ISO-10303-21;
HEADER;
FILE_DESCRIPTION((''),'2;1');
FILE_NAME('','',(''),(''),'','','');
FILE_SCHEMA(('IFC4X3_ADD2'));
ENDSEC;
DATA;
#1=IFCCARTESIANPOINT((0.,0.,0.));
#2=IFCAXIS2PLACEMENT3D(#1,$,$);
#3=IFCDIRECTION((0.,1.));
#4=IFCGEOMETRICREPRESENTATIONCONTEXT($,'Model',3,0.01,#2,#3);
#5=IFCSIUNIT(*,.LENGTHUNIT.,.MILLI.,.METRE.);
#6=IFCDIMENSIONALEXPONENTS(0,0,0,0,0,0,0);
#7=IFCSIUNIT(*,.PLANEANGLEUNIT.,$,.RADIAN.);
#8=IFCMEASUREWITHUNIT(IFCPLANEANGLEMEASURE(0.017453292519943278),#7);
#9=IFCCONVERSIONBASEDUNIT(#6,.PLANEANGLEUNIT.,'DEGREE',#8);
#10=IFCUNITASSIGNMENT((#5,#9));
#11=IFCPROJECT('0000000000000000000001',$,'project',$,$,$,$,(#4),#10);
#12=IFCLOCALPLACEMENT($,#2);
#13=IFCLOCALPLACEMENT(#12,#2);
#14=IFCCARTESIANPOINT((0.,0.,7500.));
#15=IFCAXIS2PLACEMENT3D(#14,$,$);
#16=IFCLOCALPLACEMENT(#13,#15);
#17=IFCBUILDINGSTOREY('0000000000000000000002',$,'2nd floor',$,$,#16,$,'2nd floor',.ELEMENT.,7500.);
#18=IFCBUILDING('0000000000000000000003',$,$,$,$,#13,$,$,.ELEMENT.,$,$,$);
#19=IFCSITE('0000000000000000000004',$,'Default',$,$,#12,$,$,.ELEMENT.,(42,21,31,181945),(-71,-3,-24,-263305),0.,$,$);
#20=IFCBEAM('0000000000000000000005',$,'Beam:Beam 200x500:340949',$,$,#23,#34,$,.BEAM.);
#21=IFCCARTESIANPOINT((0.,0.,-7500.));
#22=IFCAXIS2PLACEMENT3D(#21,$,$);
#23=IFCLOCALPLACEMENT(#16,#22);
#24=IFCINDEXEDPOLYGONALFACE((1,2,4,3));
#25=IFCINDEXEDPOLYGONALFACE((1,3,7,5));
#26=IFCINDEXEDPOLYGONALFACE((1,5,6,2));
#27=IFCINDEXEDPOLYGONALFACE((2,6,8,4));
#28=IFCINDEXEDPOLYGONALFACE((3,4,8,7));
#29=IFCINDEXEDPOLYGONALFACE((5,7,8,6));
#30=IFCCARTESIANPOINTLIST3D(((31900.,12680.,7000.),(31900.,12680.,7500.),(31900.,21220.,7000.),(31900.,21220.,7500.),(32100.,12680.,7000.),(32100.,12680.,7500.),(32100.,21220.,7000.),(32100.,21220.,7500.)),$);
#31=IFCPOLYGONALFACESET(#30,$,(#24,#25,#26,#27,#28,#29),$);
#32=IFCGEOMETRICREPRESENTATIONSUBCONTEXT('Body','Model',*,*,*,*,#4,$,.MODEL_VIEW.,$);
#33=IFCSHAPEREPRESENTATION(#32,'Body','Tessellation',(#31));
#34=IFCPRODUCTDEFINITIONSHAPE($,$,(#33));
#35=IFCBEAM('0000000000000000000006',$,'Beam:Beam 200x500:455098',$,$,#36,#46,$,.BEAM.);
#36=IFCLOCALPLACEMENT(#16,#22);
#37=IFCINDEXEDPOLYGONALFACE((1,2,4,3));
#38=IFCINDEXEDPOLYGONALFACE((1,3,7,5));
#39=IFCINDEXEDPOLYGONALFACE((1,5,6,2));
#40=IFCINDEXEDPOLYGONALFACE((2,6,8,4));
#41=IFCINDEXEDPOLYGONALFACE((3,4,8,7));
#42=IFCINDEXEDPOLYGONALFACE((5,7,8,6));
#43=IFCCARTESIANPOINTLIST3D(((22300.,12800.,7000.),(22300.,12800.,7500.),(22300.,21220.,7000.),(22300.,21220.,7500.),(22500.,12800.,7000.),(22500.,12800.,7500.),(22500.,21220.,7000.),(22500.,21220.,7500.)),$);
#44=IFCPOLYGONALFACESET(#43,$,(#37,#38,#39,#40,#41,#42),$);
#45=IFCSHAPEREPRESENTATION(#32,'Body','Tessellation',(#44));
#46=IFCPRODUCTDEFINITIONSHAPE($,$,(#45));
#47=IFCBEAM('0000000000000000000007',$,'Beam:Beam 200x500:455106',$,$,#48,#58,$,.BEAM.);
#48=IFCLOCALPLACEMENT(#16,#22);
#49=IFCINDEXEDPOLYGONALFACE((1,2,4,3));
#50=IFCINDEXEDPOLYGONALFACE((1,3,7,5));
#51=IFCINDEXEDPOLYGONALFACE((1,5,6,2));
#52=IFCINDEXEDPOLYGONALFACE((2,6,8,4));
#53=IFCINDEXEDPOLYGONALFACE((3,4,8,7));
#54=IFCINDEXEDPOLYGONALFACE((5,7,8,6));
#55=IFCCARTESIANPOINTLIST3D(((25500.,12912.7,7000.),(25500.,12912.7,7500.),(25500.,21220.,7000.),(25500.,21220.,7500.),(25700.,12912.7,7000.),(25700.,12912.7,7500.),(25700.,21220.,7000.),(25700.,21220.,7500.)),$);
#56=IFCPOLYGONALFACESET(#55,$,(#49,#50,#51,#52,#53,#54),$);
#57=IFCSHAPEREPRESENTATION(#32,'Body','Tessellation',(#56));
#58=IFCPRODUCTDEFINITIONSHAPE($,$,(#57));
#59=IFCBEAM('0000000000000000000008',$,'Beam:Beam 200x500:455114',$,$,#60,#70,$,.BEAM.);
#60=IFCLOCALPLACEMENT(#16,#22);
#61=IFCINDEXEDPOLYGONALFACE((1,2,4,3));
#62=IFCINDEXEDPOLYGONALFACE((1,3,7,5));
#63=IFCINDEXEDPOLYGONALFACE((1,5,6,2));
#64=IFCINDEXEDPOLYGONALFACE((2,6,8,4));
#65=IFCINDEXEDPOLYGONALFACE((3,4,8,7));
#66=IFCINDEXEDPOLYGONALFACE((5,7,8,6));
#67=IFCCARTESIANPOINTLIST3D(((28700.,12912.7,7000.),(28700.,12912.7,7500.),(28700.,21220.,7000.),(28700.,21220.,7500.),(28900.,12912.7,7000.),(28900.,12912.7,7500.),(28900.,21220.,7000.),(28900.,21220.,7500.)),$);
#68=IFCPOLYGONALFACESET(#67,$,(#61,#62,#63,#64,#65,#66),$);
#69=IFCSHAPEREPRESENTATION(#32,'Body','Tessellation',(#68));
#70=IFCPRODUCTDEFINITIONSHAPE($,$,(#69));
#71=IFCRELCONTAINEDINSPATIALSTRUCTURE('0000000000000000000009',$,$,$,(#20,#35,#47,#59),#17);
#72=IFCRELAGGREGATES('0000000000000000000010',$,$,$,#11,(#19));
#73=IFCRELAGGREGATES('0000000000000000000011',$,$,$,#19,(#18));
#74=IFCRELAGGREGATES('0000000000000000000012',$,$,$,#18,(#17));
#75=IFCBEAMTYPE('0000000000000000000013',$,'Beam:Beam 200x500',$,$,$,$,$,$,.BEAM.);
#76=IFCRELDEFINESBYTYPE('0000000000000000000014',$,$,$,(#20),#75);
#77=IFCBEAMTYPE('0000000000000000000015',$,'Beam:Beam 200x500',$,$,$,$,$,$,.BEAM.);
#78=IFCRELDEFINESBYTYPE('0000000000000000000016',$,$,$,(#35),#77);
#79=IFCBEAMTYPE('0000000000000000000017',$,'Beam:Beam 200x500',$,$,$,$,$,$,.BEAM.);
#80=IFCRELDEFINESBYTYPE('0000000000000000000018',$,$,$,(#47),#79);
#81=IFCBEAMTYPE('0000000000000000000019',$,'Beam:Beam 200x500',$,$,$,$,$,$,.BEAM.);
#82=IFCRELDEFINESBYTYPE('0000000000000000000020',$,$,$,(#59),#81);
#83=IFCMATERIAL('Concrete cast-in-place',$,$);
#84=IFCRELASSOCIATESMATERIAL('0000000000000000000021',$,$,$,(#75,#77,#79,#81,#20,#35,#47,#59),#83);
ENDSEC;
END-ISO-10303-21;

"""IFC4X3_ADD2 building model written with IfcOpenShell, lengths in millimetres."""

from ifc_helpers import new_model, entity, si_unit, converted_unit, direction, frame, frame_2d, origin, origin_2d_with_axis, place, context, subcontext, project, spatial, rectangle, extrude, source, transform, mapped, material, material_profile, profile_set, profile_usage, type_object, type_shapes, element, save


model = new_model("IFC4X3_ADD2")

# Units and contexts
model_context = context("Model", 3, precision=0.01, world=origin(), true_north=direction((0.0, 1.0)))
body_context = subcontext(model_context, "Body", "Model", "MODEL_VIEW")
ifc_project = project(units=[si_unit("LENGTHUNIT", "METRE", prefix="MILLI"), converted_unit("PLANEANGLEUNIT", "DEGREE", entity("IfcPlaneAngleMeasure", 0.017453292519943278), si_unit("PLANEANGLEUNIT", "RADIAN"), dimensions=[0, 0, 0, 0, 0, 0, 0])], contexts=[model_context])

# Site, building, storey
site_placement = place(None, origin())
site = spatial("IfcSite", under=ifc_project, at=site_placement, Name="Default", CompositionType="ELEMENT", RefLatitude=(42, 21, 31, 181945), RefLongitude=(-71, -3, -24, -263305), RefElevation=0.0)
building_placement = place(site_placement, origin())
building = spatial("IfcBuilding", under=site, at=building_placement, CompositionType="ELEMENT")
storey_placement = place(building_placement, frame((0.0, 0.0, 7500.0)))
storey = spatial("IfcBuildingStorey", under=building, at=storey_placement, Name="2nd floor", LongName="2nd floor", CompositionType="ELEMENT", Elevation=7500.0)

# Beams
ifc_material_1 = material(Name="Concrete cast-in-place")
ifc_material_profile_1 = material_profile(ifc_material_1, rectangle(XDim=8600.0, YDim=200.0, at=origin_2d_with_axis()), Name="Beam 200x500")
ifc_profile_set_1 = profile_set([ifc_material_profile_1], Name="Beam 200x500")
ifc_profile_usage_1 = profile_usage(ifc_profile_set_1, cardinal=8)
beam_type_1 = type_object("IfcBeamType", Name="Beam:Beam 200x500", PredefinedType="BEAM", material=ifc_profile_set_1)
shared_shape_1 = source(origin(), body_context, "Body", "SweptSolid", [
    extrude(rectangle(XDim=500.0, YDim=200.0, at=frame_2d((0.0, 0.0), x_axis=(0.0, 1.0))), frame((32000.0, 21220.0, 7250.0), z_axis=(0.0, -1.0, 0.0), x_axis=(-1.0, 0.0, 0.0)), (0.0, 0.0, 1.0), 8540.0),
])
type_shapes(beam_type_1, [shared_shape_1])
beam_1_placement = place(storey_placement, frame((0.0, 0.0, -7500.0)))
element("IfcBeam", 1, at=beam_1_placement, inside=storey, type_object=beam_type_1, material=ifc_profile_usage_1, Name="Beam:Beam 200x500:340949", PredefinedType="BEAM", context=body_context, shape_type="MappedRepresentation", body=[
    mapped(shared_shape_1, transform((0.0, 0.0, 0.0), scale=1.0)),
])
beam_type_2 = type_object("IfcBeamType", Name="Beam:Beam 200x500", PredefinedType="BEAM", material=ifc_profile_set_1)
shared_shape_2 = source(origin(), body_context, "Body", "SweptSolid", [
    extrude(rectangle(XDim=500.0, YDim=200.0, at=frame_2d((0.0, 0.0), x_axis=(0.0, 1.0))), frame((22400.0, 21220.0, 7250.0), z_axis=(0.0, -1.0, 0.0), x_axis=(-1.0, 0.0, 0.0)), (0.0, 0.0, 1.0), 8420.0),
])
type_shapes(beam_type_2, [shared_shape_2])
beam_2_placement = place(storey_placement, frame((0.0, 0.0, -7500.0)))
element("IfcBeam", 2, at=beam_2_placement, inside=storey, type_object=beam_type_2, material=ifc_profile_usage_1, Name="Beam:Beam 200x500:455098", PredefinedType="BEAM", context=body_context, shape_type="MappedRepresentation", body=[
    mapped(shared_shape_2, transform((0.0, 0.0, 0.0), scale=1.0)),
])
beam_type_3 = type_object("IfcBeamType", Name="Beam:Beam 200x500", PredefinedType="BEAM", material=ifc_profile_set_1)
shared_shape_3 = source(origin(), body_context, "Body", "SweptSolid", [
    extrude(rectangle(XDim=500.0, YDim=200.0, at=frame_2d((0.0, 0.0), x_axis=(0.0, 1.0))), frame((25600.0, 21220.0, 7250.0), z_axis=(0.0, -1.0, 0.0), x_axis=(-1.0, 0.0, 0.0)), (0.0, 0.0, 1.0), 8307.3),
])
type_shapes(beam_type_3, [shared_shape_3])
beam_3_placement = place(storey_placement, frame((0.0, 0.0, -7500.0)))
element("IfcBeam", 3, at=beam_3_placement, inside=storey, type_object=beam_type_3, material=ifc_profile_usage_1, Name="Beam:Beam 200x500:455106", PredefinedType="BEAM", context=body_context, shape_type="MappedRepresentation", body=[
    mapped(shared_shape_3, transform((0.0, 0.0, 0.0), scale=1.0)),
])
beam_type_4 = type_object("IfcBeamType", Name="Beam:Beam 200x500", PredefinedType="BEAM", material=ifc_profile_set_1)
shared_shape_4 = source(origin(), body_context, "Body", "SweptSolid", [
    extrude(rectangle(XDim=500.0, YDim=200.0, at=frame_2d((0.0, 0.0), x_axis=(0.0, 1.0))), frame((28800.0, 21220.0, 7250.0), z_axis=(0.0, -1.0, 0.0), x_axis=(-1.0, 0.0, 0.0)), (0.0, 0.0, 1.0), 8307.3),
])
type_shapes(beam_type_4, [shared_shape_4])
beam_4_placement = place(storey_placement, frame((0.0, 0.0, -7500.0)))
element("IfcBeam", 4, at=beam_4_placement, inside=storey, type_object=beam_type_4, material=ifc_profile_usage_1, Name="Beam:Beam 200x500:455114", PredefinedType="BEAM", context=body_context, shape_type="MappedRepresentation", body=[
    mapped(shared_shape_4, transform((0.0, 0.0, 0.0), scale=1.0)),
])

save(model, "model.ifc")
